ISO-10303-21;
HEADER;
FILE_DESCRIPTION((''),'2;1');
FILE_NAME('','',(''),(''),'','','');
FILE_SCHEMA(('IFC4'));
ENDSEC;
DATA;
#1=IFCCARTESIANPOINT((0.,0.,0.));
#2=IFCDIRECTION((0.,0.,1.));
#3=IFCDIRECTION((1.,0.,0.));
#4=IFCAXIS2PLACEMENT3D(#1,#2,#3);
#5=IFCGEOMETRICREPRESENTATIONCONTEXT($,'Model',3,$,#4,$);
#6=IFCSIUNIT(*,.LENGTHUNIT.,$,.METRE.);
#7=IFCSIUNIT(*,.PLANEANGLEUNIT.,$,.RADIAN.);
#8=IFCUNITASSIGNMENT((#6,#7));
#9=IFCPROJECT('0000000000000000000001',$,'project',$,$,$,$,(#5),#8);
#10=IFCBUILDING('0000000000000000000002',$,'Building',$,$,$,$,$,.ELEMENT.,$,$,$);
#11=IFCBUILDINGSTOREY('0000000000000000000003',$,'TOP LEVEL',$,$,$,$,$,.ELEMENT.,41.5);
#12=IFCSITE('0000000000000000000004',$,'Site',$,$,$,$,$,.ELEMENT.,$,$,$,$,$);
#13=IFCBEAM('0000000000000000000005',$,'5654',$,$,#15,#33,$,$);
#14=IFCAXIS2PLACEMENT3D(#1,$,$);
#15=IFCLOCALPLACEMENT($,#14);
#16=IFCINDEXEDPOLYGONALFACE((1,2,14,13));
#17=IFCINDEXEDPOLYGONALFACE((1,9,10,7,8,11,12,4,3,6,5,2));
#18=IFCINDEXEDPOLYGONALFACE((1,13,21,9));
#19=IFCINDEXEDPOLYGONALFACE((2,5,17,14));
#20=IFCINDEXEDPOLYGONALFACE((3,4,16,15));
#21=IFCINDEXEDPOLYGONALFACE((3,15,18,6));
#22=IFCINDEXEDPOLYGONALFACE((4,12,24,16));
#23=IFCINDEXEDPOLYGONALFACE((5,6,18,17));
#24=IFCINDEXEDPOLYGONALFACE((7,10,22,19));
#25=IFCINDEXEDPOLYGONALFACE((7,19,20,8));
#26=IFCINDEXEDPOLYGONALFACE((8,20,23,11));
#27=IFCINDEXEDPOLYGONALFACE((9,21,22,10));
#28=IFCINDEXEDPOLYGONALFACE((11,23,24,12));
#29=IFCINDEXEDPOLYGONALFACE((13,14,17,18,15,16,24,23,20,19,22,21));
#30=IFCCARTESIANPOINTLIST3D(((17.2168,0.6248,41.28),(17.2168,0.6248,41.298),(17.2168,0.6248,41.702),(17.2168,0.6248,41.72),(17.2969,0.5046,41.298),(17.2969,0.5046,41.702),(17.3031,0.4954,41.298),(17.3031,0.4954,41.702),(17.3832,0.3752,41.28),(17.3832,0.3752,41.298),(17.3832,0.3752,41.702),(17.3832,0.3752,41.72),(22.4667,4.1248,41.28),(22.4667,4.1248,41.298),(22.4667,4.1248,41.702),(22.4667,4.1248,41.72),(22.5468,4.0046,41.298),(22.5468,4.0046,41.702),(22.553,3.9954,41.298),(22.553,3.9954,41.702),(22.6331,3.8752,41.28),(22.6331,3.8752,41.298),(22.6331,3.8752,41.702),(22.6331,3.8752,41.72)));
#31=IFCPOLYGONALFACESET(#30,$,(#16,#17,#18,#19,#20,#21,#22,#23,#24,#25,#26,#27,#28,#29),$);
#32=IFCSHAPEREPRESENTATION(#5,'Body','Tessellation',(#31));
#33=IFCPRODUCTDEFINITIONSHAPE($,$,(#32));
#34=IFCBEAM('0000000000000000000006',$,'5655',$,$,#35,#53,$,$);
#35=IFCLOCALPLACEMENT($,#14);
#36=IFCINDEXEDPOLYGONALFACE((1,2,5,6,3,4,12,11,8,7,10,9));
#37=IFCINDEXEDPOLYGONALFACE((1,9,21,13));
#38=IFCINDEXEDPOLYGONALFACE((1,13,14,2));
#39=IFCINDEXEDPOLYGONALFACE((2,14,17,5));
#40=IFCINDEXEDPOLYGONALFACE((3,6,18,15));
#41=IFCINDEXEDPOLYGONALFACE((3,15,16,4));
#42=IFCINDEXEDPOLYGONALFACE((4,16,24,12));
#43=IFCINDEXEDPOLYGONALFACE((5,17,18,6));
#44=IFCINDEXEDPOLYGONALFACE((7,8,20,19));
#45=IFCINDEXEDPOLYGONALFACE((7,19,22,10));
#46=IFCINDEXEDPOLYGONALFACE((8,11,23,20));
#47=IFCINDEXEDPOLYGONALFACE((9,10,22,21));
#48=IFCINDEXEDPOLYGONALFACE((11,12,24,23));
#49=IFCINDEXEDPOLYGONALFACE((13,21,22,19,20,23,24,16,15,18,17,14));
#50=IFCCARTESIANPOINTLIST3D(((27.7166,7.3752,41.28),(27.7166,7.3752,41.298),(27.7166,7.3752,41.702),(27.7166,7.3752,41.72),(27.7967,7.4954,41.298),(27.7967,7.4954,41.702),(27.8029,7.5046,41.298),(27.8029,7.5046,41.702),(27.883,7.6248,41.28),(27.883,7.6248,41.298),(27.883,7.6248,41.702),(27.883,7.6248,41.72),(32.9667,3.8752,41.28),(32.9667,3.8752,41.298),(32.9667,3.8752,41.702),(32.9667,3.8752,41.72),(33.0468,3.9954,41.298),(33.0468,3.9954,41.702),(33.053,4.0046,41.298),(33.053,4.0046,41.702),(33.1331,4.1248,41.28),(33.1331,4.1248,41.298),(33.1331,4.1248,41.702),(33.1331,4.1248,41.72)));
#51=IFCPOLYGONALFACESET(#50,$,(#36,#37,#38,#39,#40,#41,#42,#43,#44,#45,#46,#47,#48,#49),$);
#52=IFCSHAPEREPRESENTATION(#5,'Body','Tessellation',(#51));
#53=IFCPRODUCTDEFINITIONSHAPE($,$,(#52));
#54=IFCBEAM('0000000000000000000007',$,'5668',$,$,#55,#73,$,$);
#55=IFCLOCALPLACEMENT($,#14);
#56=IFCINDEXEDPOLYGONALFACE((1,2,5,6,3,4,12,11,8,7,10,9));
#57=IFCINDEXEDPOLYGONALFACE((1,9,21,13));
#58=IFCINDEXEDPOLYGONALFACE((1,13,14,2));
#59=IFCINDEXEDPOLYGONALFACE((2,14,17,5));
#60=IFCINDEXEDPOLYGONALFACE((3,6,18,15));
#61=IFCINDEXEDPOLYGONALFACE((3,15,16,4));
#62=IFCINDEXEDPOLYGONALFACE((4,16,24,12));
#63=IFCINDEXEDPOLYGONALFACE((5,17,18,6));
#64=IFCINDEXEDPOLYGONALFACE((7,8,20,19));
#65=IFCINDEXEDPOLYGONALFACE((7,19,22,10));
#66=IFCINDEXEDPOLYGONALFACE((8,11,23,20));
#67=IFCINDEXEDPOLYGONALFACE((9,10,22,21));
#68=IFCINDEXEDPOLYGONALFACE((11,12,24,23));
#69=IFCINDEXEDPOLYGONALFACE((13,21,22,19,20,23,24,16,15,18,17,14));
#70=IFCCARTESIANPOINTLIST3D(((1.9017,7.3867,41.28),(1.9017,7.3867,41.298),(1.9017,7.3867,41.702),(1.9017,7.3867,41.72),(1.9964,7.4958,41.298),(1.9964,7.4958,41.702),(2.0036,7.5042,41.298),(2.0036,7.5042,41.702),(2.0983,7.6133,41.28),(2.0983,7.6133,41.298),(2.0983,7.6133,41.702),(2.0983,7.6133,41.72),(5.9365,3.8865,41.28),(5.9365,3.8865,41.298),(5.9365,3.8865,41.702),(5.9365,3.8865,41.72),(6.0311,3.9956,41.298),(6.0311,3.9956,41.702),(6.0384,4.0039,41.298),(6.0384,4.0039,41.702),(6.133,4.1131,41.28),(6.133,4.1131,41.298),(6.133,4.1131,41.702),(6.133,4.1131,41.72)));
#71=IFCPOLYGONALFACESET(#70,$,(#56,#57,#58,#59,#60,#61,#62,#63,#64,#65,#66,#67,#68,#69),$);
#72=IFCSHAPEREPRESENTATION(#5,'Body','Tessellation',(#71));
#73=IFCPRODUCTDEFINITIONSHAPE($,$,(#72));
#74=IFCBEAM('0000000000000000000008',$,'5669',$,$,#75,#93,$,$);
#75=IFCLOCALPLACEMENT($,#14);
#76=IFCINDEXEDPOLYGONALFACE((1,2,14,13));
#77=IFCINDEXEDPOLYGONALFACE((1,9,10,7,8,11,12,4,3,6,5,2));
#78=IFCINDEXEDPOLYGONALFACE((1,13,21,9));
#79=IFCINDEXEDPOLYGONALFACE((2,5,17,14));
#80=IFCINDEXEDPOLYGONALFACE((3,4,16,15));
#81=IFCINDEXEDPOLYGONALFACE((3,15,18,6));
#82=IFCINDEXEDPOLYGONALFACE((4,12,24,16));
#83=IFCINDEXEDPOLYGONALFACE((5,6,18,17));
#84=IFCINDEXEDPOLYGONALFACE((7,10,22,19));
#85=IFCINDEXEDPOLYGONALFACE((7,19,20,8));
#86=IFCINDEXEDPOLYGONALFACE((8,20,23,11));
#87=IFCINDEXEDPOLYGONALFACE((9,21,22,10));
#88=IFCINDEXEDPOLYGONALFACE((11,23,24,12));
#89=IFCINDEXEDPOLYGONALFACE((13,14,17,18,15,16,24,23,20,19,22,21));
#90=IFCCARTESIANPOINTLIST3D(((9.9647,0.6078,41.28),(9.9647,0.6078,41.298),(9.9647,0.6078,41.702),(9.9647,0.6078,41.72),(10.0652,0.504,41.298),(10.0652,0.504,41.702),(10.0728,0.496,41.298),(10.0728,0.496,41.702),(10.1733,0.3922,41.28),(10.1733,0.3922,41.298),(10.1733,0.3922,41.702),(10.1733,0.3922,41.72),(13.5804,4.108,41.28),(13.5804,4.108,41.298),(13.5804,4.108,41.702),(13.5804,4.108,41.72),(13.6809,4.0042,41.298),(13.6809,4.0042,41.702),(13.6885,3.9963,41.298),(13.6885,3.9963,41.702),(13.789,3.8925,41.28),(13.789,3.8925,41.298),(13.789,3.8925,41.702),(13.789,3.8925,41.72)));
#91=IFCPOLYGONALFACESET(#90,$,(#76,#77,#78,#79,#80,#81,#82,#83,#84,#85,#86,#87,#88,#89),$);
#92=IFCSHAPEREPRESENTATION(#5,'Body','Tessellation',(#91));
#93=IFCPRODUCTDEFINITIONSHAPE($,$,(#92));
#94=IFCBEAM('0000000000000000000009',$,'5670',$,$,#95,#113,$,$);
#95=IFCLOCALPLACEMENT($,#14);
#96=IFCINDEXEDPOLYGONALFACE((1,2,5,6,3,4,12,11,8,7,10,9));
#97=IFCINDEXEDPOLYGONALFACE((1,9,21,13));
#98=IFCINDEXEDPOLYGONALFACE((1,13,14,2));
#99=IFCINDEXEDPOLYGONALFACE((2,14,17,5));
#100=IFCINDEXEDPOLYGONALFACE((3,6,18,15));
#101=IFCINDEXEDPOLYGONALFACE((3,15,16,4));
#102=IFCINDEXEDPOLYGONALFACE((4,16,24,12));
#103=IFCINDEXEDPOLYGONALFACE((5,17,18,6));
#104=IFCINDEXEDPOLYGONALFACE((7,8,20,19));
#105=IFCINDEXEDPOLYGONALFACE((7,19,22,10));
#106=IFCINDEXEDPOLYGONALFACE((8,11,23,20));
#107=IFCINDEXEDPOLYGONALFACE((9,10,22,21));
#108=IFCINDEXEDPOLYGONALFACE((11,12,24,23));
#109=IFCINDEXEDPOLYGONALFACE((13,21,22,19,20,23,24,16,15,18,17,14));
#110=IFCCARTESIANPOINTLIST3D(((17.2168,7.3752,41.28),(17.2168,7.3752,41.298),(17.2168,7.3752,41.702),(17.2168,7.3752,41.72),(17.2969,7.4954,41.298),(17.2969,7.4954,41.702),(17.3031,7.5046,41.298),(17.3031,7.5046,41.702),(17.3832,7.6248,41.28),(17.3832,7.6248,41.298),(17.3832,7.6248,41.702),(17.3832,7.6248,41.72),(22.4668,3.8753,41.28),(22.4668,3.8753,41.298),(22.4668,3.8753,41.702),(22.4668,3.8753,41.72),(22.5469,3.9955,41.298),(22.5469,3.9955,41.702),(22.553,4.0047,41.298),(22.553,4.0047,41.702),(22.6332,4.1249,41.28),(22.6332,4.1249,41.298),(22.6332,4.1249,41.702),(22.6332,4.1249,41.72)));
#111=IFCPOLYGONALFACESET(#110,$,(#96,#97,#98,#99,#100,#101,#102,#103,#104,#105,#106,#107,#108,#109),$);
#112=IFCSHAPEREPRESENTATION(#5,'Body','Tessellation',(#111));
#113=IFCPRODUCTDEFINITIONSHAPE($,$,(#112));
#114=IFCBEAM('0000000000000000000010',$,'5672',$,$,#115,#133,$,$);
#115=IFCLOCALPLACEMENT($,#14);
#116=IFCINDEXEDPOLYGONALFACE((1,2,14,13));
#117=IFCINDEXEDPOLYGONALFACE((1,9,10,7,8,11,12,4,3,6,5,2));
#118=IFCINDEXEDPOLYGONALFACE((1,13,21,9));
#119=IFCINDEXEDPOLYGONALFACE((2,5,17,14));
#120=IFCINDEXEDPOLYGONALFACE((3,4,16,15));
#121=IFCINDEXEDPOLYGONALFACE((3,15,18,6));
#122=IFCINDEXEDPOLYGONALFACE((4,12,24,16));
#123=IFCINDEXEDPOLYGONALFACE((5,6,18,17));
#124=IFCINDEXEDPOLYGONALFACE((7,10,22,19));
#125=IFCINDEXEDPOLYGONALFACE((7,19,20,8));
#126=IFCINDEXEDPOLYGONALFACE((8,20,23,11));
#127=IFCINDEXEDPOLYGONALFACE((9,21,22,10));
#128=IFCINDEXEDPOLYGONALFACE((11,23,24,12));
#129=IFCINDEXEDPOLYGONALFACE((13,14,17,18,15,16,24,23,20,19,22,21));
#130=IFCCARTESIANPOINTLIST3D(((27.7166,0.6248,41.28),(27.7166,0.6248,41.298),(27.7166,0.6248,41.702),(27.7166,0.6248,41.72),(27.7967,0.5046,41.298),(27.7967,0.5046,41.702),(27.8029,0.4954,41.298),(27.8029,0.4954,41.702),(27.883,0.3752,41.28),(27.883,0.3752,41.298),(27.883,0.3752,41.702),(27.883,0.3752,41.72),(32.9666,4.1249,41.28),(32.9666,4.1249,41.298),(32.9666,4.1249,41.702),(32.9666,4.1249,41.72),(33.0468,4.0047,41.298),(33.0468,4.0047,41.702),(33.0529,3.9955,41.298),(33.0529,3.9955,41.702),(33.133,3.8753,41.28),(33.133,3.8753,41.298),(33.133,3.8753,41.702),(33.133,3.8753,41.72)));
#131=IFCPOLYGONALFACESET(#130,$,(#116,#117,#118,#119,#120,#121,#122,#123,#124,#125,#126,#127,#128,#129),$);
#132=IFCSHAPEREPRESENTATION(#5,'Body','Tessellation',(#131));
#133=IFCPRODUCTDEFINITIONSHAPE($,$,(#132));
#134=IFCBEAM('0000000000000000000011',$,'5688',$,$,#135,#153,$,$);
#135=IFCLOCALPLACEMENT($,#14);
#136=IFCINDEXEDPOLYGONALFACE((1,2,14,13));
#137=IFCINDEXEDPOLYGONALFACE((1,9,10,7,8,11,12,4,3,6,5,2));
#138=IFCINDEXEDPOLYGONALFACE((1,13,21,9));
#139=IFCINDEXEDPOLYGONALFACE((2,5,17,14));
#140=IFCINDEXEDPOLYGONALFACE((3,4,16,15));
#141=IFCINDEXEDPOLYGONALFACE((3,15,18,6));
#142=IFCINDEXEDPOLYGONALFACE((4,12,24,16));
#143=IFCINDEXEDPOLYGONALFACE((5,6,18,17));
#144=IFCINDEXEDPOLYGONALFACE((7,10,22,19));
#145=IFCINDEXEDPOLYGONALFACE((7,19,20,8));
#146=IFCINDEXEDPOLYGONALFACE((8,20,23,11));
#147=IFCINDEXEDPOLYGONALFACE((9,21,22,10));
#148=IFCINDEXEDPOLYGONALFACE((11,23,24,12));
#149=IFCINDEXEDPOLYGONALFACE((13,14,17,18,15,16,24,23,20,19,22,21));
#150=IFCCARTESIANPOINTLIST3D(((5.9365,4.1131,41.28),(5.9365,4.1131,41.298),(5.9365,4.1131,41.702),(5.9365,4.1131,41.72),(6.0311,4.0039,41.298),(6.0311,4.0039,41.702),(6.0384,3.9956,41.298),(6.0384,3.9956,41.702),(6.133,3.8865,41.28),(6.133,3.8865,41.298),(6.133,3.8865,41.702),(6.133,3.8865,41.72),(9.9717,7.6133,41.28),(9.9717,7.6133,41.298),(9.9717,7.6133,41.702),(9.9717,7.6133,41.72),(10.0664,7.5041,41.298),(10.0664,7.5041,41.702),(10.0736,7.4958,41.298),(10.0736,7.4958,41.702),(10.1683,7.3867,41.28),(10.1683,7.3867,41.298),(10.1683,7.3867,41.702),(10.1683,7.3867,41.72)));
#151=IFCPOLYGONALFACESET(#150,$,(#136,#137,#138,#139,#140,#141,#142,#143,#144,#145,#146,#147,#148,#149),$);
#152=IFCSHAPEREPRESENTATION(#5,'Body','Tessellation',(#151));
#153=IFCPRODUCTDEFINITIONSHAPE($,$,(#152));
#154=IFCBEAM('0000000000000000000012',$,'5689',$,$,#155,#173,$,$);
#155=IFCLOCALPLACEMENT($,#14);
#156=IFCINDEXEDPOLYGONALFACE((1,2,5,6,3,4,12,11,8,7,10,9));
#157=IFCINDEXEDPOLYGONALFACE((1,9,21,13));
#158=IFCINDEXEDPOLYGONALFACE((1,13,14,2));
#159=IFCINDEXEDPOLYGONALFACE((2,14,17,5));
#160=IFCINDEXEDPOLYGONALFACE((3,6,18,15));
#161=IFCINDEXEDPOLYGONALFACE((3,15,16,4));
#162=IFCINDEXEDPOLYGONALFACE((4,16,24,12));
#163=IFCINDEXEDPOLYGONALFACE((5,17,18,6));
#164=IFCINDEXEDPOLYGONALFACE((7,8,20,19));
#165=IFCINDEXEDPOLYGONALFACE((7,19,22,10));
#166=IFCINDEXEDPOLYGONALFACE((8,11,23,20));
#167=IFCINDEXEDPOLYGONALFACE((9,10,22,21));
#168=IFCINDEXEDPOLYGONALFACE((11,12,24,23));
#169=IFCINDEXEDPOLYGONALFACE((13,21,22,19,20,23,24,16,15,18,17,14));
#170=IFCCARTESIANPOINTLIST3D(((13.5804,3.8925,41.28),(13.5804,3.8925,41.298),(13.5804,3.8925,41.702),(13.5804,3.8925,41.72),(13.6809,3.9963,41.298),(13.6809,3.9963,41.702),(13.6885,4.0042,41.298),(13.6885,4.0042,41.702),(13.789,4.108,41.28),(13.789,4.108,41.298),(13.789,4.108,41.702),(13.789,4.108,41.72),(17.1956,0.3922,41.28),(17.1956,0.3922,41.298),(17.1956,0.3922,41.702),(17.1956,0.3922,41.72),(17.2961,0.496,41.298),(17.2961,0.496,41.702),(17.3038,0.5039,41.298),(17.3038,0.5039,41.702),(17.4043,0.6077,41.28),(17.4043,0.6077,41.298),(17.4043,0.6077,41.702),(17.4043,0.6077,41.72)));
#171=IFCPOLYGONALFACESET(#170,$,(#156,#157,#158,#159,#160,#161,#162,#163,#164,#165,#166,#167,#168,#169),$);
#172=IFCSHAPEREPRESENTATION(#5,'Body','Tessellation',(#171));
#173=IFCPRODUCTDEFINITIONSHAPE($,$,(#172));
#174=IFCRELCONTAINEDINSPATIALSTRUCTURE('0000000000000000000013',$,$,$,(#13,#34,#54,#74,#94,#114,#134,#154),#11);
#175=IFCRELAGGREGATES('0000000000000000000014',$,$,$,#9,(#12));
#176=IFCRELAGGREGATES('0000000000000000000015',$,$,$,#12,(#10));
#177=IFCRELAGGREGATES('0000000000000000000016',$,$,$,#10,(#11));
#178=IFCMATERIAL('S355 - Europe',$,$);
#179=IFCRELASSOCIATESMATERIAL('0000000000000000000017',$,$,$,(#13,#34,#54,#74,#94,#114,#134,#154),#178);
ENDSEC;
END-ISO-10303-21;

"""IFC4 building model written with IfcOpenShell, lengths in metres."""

from ifc_helpers import new_model, si_unit, frame, origin_with_axes, origin_2d_with_axis, place, context, project, spatial, i_section, extrude, material, material_profile, profile_set, profile_usage, element, save


model = new_model("IFC4")

# Units and contexts
model_context = context("Model", 3, world=origin_with_axes())
ifc_project = project(units=[si_unit("LENGTHUNIT", "METRE"), si_unit("PLANEANGLEUNIT", "RADIAN")], contexts=[model_context])

# Site, building, storey
site = spatial("IfcSite", under=ifc_project, Name="Site", CompositionType="ELEMENT")
building = spatial("IfcBuilding", under=site, Name="Building", CompositionType="ELEMENT")
storey = spatial("IfcBuildingStorey", under=building, Name="TOP LEVEL", CompositionType="ELEMENT", Elevation=41.5)

# Beams
ifc_material = material(Name="S355 - Europe")
ifc_material_profile_1 = material_profile(ifc_material, i_section(OverallWidth=0.3, OverallDepth=0.44, WebThickness=0.011, FlangeThickness=0.018, at=origin_2d_with_axis()))
ifc_profile_set_1 = profile_set([ifc_material_profile_1])
ifc_profile_usage_1 = profile_usage(ifc_profile_set_1, cardinal=10)
beam_1_placement = place(None, frame((17.3, 0.5, 41.5), z_axis=(0.832045, 0.554708, 0.0), x_axis=(-0.554708, 0.832045, 0.0)))
element("IfcBeam", 1, at=beam_1_placement, inside=storey, material=ifc_profile_usage_1, Name="5654", context=model_context, shape_type="SweptSolid", body=[
    extrude(i_section(OverallWidth=0.3, OverallDepth=0.44, WebThickness=0.011, FlangeThickness=0.018, at=origin_2d_with_axis()), origin_with_axes(), (0.0, 0.0, 1.0), 6.3096),
])
ifc_material_profile_2 = material_profile(ifc_material, i_section(OverallWidth=0.3, OverallDepth=0.44, WebThickness=0.011, FlangeThickness=0.018, at=origin_2d_with_axis()))
ifc_profile_set_2 = profile_set([ifc_material_profile_2])
ifc_profile_usage_2 = profile_usage(ifc_profile_set_2, cardinal=10)
beam_2_placement = place(None, frame((27.7998, 7.5, 41.5), z_axis=(0.832055, -0.554693, 0.0), x_axis=(0.554693, 0.832055, 0.0)))
element("IfcBeam", 2, at=beam_2_placement, inside=storey, material=ifc_profile_usage_2, Name="5655", context=model_context, shape_type="SweptSolid", body=[
    extrude(i_section(OverallWidth=0.3, OverallDepth=0.44, WebThickness=0.011, FlangeThickness=0.018, at=origin_2d_with_axis()), origin_with_axes(), (0.0, 0.0, 1.0), 6.3098),
])
ifc_material_profile_3 = material_profile(ifc_material, i_section(OverallWidth=0.3, OverallDepth=0.44, WebThickness=0.011, FlangeThickness=0.018, at=origin_2d_with_axis()))
ifc_profile_set_3 = profile_set([ifc_material_profile_3])
ifc_profile_usage_3 = profile_usage(ifc_profile_set_3, cardinal=10)
beam_3_placement = place(None, frame((2.0, 7.5, 41.5), z_axis=(0.75537, -0.655299, 0.0), x_axis=(0.655299, 0.75537, 0.0)))
element("IfcBeam", 3, at=beam_3_placement, inside=storey, material=ifc_profile_usage_3, Name="5668", context=model_context, shape_type="SweptSolid", body=[
    extrude(i_section(OverallWidth=0.3, OverallDepth=0.44, WebThickness=0.011, FlangeThickness=0.018, at=origin_2d_with_axis()), origin_with_axes(), (0.0, 0.0, 1.0), 5.3414),
])
ifc_material_profile_4 = material_profile(ifc_material, i_section(OverallWidth=0.3, OverallDepth=0.44, WebThickness=0.011, FlangeThickness=0.018, at=origin_2d_with_axis()))
ifc_profile_set_4 = profile_set([ifc_material_profile_4])
ifc_profile_usage_4 = profile_usage(ifc_profile_set_4, cardinal=10)
beam_4_placement = place(None, frame((10.069, 0.5, 41.5), z_axis=(0.718483, 0.695544, 0.0), x_axis=(-0.695544, 0.718483, 0.0)))
element("IfcBeam", 4, at=beam_4_placement, inside=storey, material=ifc_profile_usage_4, Name="5669", context=model_context, shape_type="SweptSolid", body=[
    extrude(i_section(OverallWidth=0.3, OverallDepth=0.44, WebThickness=0.011, FlangeThickness=0.018, at=origin_2d_with_axis()), origin_with_axes(), (0.0, 0.0, 1.0), 5.0324),
])
ifc_material_profile_5 = material_profile(ifc_material, i_section(OverallWidth=0.3, OverallDepth=0.44, WebThickness=0.011, FlangeThickness=0.018, at=origin_2d_with_axis()))
ifc_profile_set_5 = profile_set([ifc_material_profile_5])
ifc_profile_usage_5 = profile_usage(ifc_profile_set_5, cardinal=10)
beam_5_placement = place(None, frame((17.3, 7.5, 41.5), z_axis=(0.832055, -0.554693, 0.0), x_axis=(0.554693, 0.832055, 0.0)))
element("IfcBeam", 5, at=beam_5_placement, inside=storey, material=ifc_profile_usage_5, Name="5670", context=model_context, shape_type="SweptSolid", body=[
    extrude(i_section(OverallWidth=0.3, OverallDepth=0.44, WebThickness=0.011, FlangeThickness=0.018, at=origin_2d_with_axis()), origin_with_axes(), (0.0, 0.0, 1.0), 6.3096),
])
ifc_material_profile_6 = material_profile(ifc_material, i_section(OverallWidth=0.3, OverallDepth=0.44, WebThickness=0.011, FlangeThickness=0.018, at=origin_2d_with_axis()))
ifc_profile_set_6 = profile_set([ifc_material_profile_6])
ifc_profile_usage_6 = profile_usage(ifc_profile_set_6, cardinal=10)
beam_6_placement = place(None, frame((27.7998, 0.5, 41.5), z_axis=(0.832045, 0.554708, 0.0), x_axis=(-0.554708, 0.832045, 0.0)))
element("IfcBeam", 6, at=beam_6_placement, inside=storey, material=ifc_profile_usage_6, Name="5672", context=model_context, shape_type="SweptSolid", body=[
    extrude(i_section(OverallWidth=0.3, OverallDepth=0.44, WebThickness=0.011, FlangeThickness=0.018, at=origin_2d_with_axis()), origin_with_axes(), (0.0, 0.0, 1.0), 6.3098),
])
ifc_material_profile_7 = material_profile(ifc_material, i_section(OverallWidth=0.3, OverallDepth=0.44, WebThickness=0.011, FlangeThickness=0.018, at=origin_2d_with_axis()))
ifc_profile_set_7 = profile_set([ifc_material_profile_7])
ifc_profile_usage_7 = profile_usage(ifc_profile_set_7, cardinal=10)
beam_7_placement = place(None, frame((6.0347, 3.9998, 41.5), z_axis=(0.755412, 0.65525, 0.0), x_axis=(-0.65525, 0.755412, 0.0)))
element("IfcBeam", 7, at=beam_7_placement, inside=storey, material=ifc_profile_usage_7, Name="5688", context=model_context, shape_type="SweptSolid", body=[
    extrude(i_section(OverallWidth=0.3, OverallDepth=0.44, WebThickness=0.011, FlangeThickness=0.018, at=origin_2d_with_axis()), origin_with_axes(), (0.0, 0.0, 1.0), 5.3418),
])
ifc_material_profile_8 = material_profile(ifc_material, i_section(OverallWidth=0.3, OverallDepth=0.44, WebThickness=0.011, FlangeThickness=0.018, at=origin_2d_with_axis()))
ifc_profile_set_8 = profile_set([ifc_material_profile_8])
ifc_profile_usage_8 = profile_usage(ifc_profile_set_8, cardinal=10)
beam_8_placement = place(None, frame((13.6847, 4.0003, 41.5), z_axis=(0.718439, -0.69559, 0.0), x_axis=(0.69559, 0.718439, 0.0)))
element("IfcBeam", 8, at=beam_8_placement, inside=storey, material=ifc_profile_usage_8, Name="5689", context=model_context, shape_type="SweptSolid", body=[
    extrude(i_section(OverallWidth=0.3, OverallDepth=0.44, WebThickness=0.011, FlangeThickness=0.018, at=origin_2d_with_axis()), origin_with_axes(), (0.0, 0.0, 1.0), 5.0321),
])

save(model, "model.ifc")
